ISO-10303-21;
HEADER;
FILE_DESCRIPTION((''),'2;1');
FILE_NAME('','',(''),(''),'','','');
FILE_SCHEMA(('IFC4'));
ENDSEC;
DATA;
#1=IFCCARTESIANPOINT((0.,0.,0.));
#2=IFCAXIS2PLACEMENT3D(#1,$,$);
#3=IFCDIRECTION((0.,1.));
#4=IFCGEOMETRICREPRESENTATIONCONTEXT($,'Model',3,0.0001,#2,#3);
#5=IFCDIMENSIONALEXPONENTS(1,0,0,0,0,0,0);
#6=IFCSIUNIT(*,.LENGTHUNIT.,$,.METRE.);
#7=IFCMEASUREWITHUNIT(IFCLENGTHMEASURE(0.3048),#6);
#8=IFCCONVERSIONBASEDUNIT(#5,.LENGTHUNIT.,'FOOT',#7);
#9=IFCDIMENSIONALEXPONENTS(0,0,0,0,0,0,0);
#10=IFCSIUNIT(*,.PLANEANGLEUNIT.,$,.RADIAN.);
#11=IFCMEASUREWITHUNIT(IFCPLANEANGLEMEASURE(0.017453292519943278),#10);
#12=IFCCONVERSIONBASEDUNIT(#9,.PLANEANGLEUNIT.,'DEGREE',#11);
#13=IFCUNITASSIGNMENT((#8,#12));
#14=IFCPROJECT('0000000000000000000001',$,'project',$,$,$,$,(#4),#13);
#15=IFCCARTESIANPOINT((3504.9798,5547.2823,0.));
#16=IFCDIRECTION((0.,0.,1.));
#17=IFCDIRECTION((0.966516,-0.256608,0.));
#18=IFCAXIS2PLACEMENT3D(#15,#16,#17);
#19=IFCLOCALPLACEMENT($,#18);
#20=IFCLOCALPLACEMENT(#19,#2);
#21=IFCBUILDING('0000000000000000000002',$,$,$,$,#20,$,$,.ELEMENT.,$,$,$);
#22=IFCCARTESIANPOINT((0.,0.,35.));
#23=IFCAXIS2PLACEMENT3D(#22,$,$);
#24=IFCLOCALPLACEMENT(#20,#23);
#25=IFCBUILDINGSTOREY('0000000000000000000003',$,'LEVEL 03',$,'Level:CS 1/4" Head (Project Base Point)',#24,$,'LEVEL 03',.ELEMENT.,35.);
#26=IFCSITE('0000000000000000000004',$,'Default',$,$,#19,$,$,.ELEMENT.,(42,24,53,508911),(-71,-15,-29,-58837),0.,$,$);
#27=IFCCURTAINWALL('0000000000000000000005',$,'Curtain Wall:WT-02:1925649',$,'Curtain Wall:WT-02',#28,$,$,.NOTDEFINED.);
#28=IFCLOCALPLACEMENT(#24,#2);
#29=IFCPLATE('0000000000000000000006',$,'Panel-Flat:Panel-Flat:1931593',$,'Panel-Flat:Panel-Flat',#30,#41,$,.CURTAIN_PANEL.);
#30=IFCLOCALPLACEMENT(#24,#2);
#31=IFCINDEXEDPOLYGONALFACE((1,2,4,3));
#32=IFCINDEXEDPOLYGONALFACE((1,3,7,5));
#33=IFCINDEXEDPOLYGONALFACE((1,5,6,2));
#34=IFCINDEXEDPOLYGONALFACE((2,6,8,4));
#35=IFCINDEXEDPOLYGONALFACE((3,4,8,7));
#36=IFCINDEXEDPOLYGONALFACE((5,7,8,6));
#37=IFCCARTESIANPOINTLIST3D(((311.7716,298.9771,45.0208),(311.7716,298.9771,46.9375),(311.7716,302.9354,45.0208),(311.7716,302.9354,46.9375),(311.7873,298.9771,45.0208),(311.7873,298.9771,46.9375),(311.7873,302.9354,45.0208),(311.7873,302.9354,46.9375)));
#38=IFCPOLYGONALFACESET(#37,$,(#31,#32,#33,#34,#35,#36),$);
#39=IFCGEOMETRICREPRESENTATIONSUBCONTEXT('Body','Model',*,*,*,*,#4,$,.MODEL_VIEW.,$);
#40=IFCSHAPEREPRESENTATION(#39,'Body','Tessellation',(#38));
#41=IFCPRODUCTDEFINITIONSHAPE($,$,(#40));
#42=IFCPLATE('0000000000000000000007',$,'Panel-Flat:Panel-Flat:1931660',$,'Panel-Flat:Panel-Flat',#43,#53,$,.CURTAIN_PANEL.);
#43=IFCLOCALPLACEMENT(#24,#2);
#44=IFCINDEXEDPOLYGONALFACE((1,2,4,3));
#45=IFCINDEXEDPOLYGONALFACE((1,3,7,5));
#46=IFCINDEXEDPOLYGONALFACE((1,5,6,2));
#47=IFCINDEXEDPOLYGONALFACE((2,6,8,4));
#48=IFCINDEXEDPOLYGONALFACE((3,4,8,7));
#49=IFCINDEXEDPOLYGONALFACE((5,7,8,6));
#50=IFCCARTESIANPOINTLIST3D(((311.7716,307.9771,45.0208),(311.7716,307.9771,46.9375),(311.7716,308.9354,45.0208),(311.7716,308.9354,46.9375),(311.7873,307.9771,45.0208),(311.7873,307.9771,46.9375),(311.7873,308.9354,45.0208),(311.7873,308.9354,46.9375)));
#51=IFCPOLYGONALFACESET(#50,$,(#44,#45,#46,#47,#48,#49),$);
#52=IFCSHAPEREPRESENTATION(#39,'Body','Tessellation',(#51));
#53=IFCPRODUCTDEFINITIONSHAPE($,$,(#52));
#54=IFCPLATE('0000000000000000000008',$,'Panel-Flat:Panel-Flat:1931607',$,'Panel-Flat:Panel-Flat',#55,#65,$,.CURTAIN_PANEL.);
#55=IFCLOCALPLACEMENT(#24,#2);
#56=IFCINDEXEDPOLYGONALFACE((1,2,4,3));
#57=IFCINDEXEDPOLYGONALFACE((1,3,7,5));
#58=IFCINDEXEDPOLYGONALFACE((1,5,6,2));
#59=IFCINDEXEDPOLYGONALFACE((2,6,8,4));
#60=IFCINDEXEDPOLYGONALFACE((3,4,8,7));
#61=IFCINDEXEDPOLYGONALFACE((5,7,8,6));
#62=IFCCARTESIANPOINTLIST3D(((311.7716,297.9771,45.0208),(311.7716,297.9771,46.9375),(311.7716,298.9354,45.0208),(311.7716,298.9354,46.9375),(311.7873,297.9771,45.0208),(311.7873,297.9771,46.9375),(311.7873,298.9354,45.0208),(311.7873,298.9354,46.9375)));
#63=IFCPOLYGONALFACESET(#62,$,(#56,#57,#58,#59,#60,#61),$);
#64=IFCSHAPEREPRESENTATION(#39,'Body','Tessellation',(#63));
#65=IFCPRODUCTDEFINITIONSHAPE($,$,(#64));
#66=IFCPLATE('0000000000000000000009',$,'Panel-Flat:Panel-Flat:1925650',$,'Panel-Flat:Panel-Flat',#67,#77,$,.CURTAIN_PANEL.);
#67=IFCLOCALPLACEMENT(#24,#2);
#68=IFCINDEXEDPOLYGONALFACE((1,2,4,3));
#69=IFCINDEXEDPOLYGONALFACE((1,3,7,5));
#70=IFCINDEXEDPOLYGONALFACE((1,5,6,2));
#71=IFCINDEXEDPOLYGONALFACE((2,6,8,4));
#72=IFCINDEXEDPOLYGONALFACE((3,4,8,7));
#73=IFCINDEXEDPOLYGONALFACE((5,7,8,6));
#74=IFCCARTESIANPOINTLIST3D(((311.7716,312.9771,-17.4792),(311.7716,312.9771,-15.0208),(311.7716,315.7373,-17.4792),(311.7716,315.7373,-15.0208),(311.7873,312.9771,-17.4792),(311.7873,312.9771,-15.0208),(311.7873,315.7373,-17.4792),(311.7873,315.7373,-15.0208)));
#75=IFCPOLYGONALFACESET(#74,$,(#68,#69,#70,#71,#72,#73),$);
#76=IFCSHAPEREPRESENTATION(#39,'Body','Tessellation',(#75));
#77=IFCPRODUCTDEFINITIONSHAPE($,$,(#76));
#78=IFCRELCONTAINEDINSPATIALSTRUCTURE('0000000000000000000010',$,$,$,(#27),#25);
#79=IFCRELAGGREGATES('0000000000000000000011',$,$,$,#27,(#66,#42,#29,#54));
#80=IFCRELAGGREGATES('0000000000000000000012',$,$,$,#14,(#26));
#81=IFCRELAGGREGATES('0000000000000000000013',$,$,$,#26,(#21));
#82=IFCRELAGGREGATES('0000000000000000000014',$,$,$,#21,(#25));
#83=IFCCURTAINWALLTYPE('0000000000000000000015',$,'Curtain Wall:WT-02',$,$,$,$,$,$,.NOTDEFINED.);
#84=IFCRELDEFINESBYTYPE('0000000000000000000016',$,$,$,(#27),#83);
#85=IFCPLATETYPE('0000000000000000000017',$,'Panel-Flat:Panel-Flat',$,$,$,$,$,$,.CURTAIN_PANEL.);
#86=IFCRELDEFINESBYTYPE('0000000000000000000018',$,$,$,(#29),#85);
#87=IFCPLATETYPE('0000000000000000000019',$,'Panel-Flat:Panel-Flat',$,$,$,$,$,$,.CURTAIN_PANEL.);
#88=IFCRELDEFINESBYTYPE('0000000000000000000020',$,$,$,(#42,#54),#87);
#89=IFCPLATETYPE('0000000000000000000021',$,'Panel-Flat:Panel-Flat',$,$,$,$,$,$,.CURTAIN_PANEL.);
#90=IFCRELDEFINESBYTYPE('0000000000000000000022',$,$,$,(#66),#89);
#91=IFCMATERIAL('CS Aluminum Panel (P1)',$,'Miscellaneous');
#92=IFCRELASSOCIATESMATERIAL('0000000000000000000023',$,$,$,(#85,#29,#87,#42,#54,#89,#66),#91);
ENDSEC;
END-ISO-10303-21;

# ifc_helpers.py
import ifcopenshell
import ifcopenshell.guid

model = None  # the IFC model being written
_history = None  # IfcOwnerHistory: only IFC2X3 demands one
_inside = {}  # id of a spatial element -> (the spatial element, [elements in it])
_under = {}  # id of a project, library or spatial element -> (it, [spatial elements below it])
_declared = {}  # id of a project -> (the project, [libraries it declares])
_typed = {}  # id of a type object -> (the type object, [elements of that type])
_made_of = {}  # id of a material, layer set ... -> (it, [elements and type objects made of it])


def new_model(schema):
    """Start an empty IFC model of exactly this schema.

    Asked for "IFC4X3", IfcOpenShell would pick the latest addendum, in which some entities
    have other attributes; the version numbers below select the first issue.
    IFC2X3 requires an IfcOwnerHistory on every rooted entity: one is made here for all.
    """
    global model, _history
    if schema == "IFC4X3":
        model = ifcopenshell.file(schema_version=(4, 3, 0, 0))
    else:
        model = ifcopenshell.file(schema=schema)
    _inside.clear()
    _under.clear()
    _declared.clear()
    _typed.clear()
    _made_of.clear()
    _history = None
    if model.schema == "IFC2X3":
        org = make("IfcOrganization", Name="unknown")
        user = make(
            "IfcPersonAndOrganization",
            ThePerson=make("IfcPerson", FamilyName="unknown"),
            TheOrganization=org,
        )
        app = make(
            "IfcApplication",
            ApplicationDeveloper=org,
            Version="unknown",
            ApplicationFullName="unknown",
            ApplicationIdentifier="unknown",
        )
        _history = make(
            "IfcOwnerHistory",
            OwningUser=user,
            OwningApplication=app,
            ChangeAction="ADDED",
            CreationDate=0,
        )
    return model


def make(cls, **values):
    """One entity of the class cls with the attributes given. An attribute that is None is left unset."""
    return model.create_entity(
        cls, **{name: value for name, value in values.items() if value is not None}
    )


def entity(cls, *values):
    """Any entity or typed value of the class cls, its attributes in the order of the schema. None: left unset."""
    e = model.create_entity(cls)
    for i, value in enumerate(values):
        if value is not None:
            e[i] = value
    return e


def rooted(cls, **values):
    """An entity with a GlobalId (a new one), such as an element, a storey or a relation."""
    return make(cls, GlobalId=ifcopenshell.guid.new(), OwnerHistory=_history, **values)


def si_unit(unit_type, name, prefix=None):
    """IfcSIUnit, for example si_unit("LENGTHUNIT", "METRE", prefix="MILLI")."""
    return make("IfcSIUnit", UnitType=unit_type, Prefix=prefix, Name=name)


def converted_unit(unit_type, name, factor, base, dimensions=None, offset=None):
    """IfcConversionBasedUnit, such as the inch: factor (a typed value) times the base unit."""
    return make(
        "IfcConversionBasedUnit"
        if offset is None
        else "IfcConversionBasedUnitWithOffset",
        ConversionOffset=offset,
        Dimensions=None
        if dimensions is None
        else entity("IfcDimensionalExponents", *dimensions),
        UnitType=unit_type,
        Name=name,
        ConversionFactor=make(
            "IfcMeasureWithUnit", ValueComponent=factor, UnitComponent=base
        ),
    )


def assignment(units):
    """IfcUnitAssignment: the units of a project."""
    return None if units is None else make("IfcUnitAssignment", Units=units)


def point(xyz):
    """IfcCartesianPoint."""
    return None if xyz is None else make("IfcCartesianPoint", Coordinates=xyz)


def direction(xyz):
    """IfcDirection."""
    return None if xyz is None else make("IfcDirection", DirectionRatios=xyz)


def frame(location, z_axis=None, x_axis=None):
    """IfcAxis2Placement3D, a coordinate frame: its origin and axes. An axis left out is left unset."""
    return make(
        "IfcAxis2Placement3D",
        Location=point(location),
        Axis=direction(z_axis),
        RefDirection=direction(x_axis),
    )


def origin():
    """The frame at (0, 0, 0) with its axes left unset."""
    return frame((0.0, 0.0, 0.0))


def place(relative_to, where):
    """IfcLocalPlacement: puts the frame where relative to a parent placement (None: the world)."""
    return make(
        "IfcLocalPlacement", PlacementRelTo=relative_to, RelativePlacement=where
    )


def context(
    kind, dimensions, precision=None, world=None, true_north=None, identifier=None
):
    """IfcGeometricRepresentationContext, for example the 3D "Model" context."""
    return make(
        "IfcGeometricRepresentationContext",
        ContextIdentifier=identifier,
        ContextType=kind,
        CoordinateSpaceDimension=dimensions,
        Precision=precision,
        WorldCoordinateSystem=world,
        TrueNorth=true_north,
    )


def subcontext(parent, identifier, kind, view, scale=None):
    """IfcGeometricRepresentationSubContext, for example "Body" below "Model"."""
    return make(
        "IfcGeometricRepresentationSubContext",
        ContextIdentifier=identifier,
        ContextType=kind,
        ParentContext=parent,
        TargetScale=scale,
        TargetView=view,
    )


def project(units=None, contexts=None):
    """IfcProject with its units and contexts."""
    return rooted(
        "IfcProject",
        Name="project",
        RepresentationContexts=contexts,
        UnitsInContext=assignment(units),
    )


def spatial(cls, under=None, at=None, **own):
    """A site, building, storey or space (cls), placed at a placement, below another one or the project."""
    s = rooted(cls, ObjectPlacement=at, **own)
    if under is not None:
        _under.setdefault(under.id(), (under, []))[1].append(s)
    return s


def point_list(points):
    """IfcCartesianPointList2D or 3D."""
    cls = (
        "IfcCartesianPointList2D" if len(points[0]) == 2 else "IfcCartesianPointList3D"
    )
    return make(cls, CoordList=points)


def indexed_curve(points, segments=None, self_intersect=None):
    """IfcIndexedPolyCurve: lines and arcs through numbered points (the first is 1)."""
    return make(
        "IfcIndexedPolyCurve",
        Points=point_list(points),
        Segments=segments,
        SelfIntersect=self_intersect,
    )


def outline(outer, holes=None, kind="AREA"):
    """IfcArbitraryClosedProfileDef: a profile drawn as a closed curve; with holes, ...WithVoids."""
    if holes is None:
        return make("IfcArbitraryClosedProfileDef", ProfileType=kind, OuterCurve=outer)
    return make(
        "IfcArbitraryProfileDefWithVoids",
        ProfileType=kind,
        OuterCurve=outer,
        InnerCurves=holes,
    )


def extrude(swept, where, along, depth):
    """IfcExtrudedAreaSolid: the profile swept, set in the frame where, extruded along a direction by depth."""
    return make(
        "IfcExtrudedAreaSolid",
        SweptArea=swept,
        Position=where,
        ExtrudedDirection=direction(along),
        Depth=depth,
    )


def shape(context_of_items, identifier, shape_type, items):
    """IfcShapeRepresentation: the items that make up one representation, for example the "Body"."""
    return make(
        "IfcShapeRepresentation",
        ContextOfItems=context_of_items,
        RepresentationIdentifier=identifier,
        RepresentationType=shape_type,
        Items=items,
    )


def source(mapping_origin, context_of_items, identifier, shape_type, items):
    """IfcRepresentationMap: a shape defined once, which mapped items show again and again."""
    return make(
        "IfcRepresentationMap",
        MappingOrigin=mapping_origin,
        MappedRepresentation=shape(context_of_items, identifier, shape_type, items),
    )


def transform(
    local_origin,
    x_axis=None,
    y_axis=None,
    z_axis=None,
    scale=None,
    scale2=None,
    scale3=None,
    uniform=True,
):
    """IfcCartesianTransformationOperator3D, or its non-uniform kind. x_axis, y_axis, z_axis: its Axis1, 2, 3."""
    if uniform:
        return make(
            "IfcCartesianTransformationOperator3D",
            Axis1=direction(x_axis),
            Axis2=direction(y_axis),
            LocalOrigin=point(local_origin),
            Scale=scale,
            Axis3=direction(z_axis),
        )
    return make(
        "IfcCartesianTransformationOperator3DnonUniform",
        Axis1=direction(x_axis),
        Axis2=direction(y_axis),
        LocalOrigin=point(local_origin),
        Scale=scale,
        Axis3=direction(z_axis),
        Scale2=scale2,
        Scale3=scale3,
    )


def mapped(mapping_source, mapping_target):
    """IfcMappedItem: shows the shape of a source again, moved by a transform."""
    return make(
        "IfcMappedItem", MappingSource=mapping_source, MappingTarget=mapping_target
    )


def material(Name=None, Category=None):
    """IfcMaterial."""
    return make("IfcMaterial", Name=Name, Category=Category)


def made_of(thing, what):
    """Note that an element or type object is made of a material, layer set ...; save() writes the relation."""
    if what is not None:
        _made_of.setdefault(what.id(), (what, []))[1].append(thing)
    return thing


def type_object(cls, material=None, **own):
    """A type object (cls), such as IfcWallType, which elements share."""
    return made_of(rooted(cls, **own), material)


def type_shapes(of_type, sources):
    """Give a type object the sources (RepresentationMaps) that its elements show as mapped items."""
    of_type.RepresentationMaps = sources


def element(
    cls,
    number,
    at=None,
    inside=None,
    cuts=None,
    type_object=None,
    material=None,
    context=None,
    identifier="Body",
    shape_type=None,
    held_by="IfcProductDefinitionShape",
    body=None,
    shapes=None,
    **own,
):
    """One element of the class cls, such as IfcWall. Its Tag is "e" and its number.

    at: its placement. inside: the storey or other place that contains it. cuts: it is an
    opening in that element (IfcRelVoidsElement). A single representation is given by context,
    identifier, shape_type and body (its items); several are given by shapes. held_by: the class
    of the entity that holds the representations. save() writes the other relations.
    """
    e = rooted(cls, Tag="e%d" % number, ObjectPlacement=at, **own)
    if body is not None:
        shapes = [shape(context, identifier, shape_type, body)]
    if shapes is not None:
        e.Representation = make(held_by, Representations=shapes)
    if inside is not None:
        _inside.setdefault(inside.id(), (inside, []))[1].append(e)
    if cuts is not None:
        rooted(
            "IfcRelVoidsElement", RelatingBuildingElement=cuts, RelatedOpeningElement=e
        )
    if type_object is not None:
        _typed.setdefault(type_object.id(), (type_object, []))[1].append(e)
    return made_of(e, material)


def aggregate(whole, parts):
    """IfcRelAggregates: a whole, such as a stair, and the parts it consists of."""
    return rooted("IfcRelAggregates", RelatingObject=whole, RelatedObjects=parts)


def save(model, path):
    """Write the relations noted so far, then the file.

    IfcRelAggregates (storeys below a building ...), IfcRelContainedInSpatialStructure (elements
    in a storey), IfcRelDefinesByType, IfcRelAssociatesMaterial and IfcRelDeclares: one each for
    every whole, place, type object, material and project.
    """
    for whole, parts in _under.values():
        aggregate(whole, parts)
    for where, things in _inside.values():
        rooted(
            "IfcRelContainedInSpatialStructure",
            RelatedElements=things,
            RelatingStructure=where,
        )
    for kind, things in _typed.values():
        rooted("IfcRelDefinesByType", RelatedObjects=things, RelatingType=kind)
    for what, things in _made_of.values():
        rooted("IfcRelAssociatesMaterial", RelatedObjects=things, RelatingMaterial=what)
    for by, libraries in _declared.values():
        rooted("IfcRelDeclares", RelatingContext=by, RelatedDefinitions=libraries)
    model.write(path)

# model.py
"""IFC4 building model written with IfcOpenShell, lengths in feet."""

from ifc_helpers import new_model, entity, si_unit, converted_unit, direction, frame, origin, place, context, subcontext, project, spatial, indexed_curve, outline, extrude, source, transform, mapped, material, type_object, type_shapes, element, aggregate, save


model = new_model("IFC4")

# Units and contexts
model_context = context("Model", 3, precision=0.0001, world=origin(), true_north=direction((0.0, 1.0)))
body_context = subcontext(model_context, "Body", "Model", "MODEL_VIEW")
ifc_project = project(units=[converted_unit("LENGTHUNIT", "FOOT", entity("IfcLengthMeasure", 0.3048), si_unit("LENGTHUNIT", "METRE"), dimensions=[1, 0, 0, 0, 0, 0, 0]), converted_unit("PLANEANGLEUNIT", "DEGREE", entity("IfcPlaneAngleMeasure", 0.017453292519943278), si_unit("PLANEANGLEUNIT", "RADIAN"), dimensions=[0, 0, 0, 0, 0, 0, 0])], contexts=[model_context])

# Site, building, storey
site_placement = place(None, frame((3504.9798, 5547.2823, 0.0), z_axis=(0.0, 0.0, 1.0), x_axis=(0.966516, -0.256608, 0.0)))
site = spatial("IfcSite", under=ifc_project, at=site_placement, Name="Default", CompositionType="ELEMENT", RefLatitude=(42, 24, 53, 508911), RefLongitude=(-71, -15, -29, -58837), RefElevation=0.0)
building_placement = place(site_placement, origin())
building = spatial("IfcBuilding", under=site, at=building_placement, CompositionType="ELEMENT")
storey_placement = place(building_placement, frame((0.0, 0.0, 35.0)))
storey = spatial("IfcBuildingStorey", under=building, at=storey_placement, Name="LEVEL 03", ObjectType="Level:CS 1/4\" Head (Project Base Point)", LongName="LEVEL 03", CompositionType="ELEMENT", Elevation=35.0)

# Curtain wall
curtain_wall_type = type_object("IfcCurtainWallType", Name="Curtain Wall:WT-02", PredefinedType="NOTDEFINED")
curtain_wall_1_placement = place(storey_placement, frame((0.0, 0.0, -35.0)))
curtain_wall_1 = element("IfcCurtainWall", 1, at=curtain_wall_1_placement, inside=storey, type_object=curtain_wall_type, Name="Curtain Wall:WT-02:1925649", ObjectType="Curtain Wall:WT-02", PredefinedType="NOTDEFINED")
ifc_material_1 = material(Name="CS Aluminum Panel (P1)", Category="Miscellaneous")

# Plates
plate_type_1 = type_object("IfcPlateType", Name="Panel-Flat:Panel-Flat", PredefinedType="CURTAIN_PANEL", material=ifc_material_1)
shared_shape_1 = source(origin(), body_context, "Body", "SweptSolid", [
    extrude(outline(indexed_curve([(-0.0078, -1.9792), (0.0078, -1.9792), (0.0078, 1.9792), (-0.0078, 1.9792), (-0.0078, -1.9792)], self_intersect=False)), frame((0.0, -0.0078, 0.0208), z_axis=(0.0, 0.0, 1.0), x_axis=(0.0, -1.0, 0.0)), (0.0, 0.0, 1.0), 1.9167),
])
type_shapes(plate_type_1, [shared_shape_1])
plate_1_placement = place(curtain_wall_1_placement, frame((311.7873, 300.9563, 80.0), z_axis=(0.0, 0.0, 1.0), x_axis=(0.0, -1.0, 0.0)))
plate_1 = element("IfcPlate", 2, at=plate_1_placement, type_object=plate_type_1, material=ifc_material_1, Name="Panel-Flat:Panel-Flat:1931593", ObjectType="Panel-Flat:Panel-Flat", PredefinedType="CURTAIN_PANEL", context=body_context, shape_type="MappedRepresentation", body=[
    mapped(shared_shape_1, transform((0.0, 0.0, 0.0), scale=1.0)),
])
plate_type_2 = type_object("IfcPlateType", Name="Panel-Flat:Panel-Flat", PredefinedType="CURTAIN_PANEL", material=ifc_material_1)
shared_shape_2 = source(origin(), body_context, "Body", "SweptSolid", [
    extrude(outline(indexed_curve([(-0.0078, -0.4792), (0.0078, -0.4792), (0.0078, 0.4792), (-0.0078, 0.4792), (-0.0078, -0.4792)], self_intersect=False)), frame((0.0, -0.0078, 0.0208), z_axis=(0.0, 0.0, 1.0), x_axis=(0.0, -1.0, 0.0)), (0.0, 0.0, 1.0), 1.9167),
])
type_shapes(plate_type_2, [shared_shape_2])
plate_2_placement = place(curtain_wall_1_placement, frame((311.7873, 308.4563, 80.0), z_axis=(0.0, 0.0, 1.0), x_axis=(0.0, -1.0, 0.0)))
plate_2 = element("IfcPlate", 3, at=plate_2_placement, type_object=plate_type_2, material=ifc_material_1, Name="Panel-Flat:Panel-Flat:1931660", ObjectType="Panel-Flat:Panel-Flat", PredefinedType="CURTAIN_PANEL", context=body_context, shape_type="MappedRepresentation", body=[
    mapped(shared_shape_2, transform((0.0, 0.0, 0.0), scale=1.0)),
])
plate_3_placement = place(curtain_wall_1_placement, frame((311.7873, 298.4563, 80.0), z_axis=(0.0, 0.0, 1.0), x_axis=(0.0, -1.0, 0.0)))
plate_3 = element("IfcPlate", 4, at=plate_3_placement, type_object=plate_type_2, material=ifc_material_1, Name="Panel-Flat:Panel-Flat:1931607", ObjectType="Panel-Flat:Panel-Flat", PredefinedType="CURTAIN_PANEL", context=body_context, shape_type="MappedRepresentation", body=[
    mapped(shared_shape_2, transform((0.0, 0.0, 0.0), scale=1.0)),
])
plate_type_3 = type_object("IfcPlateType", Name="Panel-Flat:Panel-Flat", PredefinedType="CURTAIN_PANEL", material=ifc_material_1)
shared_shape_3 = source(origin(), body_context, "Body", "SweptSolid", [
    extrude(outline(indexed_curve([(-0.0078, -1.3801), (0.0078, -1.3801), (0.0078, 1.3801), (-0.0078, 1.3801), (-0.0078, -1.3801)], self_intersect=False)), frame((0.0, -0.0078, 0.0208), z_axis=(0.0, 0.0, 1.0), x_axis=(0.0, -1.0, 0.0)), (0.0, 0.0, 1.0), 2.4583),
])
type_shapes(plate_type_3, [shared_shape_3])
plate_4_placement = place(curtain_wall_1_placement, frame((311.7873, 314.3572, 17.5), z_axis=(0.0, 0.0, 1.0), x_axis=(0.0, -1.0, 0.0)))
plate_4 = element("IfcPlate", 5, at=plate_4_placement, type_object=plate_type_3, material=ifc_material_1, Name="Panel-Flat:Panel-Flat:1925650", ObjectType="Panel-Flat:Panel-Flat", PredefinedType="CURTAIN_PANEL", context=body_context, shape_type="MappedRepresentation", body=[
    mapped(shared_shape_3, transform((0.0, 0.0, 0.0), scale=1.0)),
])
aggregate(curtain_wall_1, [plate_4, plate_2, plate_1, plate_3])

save(model, "model.ifc")
